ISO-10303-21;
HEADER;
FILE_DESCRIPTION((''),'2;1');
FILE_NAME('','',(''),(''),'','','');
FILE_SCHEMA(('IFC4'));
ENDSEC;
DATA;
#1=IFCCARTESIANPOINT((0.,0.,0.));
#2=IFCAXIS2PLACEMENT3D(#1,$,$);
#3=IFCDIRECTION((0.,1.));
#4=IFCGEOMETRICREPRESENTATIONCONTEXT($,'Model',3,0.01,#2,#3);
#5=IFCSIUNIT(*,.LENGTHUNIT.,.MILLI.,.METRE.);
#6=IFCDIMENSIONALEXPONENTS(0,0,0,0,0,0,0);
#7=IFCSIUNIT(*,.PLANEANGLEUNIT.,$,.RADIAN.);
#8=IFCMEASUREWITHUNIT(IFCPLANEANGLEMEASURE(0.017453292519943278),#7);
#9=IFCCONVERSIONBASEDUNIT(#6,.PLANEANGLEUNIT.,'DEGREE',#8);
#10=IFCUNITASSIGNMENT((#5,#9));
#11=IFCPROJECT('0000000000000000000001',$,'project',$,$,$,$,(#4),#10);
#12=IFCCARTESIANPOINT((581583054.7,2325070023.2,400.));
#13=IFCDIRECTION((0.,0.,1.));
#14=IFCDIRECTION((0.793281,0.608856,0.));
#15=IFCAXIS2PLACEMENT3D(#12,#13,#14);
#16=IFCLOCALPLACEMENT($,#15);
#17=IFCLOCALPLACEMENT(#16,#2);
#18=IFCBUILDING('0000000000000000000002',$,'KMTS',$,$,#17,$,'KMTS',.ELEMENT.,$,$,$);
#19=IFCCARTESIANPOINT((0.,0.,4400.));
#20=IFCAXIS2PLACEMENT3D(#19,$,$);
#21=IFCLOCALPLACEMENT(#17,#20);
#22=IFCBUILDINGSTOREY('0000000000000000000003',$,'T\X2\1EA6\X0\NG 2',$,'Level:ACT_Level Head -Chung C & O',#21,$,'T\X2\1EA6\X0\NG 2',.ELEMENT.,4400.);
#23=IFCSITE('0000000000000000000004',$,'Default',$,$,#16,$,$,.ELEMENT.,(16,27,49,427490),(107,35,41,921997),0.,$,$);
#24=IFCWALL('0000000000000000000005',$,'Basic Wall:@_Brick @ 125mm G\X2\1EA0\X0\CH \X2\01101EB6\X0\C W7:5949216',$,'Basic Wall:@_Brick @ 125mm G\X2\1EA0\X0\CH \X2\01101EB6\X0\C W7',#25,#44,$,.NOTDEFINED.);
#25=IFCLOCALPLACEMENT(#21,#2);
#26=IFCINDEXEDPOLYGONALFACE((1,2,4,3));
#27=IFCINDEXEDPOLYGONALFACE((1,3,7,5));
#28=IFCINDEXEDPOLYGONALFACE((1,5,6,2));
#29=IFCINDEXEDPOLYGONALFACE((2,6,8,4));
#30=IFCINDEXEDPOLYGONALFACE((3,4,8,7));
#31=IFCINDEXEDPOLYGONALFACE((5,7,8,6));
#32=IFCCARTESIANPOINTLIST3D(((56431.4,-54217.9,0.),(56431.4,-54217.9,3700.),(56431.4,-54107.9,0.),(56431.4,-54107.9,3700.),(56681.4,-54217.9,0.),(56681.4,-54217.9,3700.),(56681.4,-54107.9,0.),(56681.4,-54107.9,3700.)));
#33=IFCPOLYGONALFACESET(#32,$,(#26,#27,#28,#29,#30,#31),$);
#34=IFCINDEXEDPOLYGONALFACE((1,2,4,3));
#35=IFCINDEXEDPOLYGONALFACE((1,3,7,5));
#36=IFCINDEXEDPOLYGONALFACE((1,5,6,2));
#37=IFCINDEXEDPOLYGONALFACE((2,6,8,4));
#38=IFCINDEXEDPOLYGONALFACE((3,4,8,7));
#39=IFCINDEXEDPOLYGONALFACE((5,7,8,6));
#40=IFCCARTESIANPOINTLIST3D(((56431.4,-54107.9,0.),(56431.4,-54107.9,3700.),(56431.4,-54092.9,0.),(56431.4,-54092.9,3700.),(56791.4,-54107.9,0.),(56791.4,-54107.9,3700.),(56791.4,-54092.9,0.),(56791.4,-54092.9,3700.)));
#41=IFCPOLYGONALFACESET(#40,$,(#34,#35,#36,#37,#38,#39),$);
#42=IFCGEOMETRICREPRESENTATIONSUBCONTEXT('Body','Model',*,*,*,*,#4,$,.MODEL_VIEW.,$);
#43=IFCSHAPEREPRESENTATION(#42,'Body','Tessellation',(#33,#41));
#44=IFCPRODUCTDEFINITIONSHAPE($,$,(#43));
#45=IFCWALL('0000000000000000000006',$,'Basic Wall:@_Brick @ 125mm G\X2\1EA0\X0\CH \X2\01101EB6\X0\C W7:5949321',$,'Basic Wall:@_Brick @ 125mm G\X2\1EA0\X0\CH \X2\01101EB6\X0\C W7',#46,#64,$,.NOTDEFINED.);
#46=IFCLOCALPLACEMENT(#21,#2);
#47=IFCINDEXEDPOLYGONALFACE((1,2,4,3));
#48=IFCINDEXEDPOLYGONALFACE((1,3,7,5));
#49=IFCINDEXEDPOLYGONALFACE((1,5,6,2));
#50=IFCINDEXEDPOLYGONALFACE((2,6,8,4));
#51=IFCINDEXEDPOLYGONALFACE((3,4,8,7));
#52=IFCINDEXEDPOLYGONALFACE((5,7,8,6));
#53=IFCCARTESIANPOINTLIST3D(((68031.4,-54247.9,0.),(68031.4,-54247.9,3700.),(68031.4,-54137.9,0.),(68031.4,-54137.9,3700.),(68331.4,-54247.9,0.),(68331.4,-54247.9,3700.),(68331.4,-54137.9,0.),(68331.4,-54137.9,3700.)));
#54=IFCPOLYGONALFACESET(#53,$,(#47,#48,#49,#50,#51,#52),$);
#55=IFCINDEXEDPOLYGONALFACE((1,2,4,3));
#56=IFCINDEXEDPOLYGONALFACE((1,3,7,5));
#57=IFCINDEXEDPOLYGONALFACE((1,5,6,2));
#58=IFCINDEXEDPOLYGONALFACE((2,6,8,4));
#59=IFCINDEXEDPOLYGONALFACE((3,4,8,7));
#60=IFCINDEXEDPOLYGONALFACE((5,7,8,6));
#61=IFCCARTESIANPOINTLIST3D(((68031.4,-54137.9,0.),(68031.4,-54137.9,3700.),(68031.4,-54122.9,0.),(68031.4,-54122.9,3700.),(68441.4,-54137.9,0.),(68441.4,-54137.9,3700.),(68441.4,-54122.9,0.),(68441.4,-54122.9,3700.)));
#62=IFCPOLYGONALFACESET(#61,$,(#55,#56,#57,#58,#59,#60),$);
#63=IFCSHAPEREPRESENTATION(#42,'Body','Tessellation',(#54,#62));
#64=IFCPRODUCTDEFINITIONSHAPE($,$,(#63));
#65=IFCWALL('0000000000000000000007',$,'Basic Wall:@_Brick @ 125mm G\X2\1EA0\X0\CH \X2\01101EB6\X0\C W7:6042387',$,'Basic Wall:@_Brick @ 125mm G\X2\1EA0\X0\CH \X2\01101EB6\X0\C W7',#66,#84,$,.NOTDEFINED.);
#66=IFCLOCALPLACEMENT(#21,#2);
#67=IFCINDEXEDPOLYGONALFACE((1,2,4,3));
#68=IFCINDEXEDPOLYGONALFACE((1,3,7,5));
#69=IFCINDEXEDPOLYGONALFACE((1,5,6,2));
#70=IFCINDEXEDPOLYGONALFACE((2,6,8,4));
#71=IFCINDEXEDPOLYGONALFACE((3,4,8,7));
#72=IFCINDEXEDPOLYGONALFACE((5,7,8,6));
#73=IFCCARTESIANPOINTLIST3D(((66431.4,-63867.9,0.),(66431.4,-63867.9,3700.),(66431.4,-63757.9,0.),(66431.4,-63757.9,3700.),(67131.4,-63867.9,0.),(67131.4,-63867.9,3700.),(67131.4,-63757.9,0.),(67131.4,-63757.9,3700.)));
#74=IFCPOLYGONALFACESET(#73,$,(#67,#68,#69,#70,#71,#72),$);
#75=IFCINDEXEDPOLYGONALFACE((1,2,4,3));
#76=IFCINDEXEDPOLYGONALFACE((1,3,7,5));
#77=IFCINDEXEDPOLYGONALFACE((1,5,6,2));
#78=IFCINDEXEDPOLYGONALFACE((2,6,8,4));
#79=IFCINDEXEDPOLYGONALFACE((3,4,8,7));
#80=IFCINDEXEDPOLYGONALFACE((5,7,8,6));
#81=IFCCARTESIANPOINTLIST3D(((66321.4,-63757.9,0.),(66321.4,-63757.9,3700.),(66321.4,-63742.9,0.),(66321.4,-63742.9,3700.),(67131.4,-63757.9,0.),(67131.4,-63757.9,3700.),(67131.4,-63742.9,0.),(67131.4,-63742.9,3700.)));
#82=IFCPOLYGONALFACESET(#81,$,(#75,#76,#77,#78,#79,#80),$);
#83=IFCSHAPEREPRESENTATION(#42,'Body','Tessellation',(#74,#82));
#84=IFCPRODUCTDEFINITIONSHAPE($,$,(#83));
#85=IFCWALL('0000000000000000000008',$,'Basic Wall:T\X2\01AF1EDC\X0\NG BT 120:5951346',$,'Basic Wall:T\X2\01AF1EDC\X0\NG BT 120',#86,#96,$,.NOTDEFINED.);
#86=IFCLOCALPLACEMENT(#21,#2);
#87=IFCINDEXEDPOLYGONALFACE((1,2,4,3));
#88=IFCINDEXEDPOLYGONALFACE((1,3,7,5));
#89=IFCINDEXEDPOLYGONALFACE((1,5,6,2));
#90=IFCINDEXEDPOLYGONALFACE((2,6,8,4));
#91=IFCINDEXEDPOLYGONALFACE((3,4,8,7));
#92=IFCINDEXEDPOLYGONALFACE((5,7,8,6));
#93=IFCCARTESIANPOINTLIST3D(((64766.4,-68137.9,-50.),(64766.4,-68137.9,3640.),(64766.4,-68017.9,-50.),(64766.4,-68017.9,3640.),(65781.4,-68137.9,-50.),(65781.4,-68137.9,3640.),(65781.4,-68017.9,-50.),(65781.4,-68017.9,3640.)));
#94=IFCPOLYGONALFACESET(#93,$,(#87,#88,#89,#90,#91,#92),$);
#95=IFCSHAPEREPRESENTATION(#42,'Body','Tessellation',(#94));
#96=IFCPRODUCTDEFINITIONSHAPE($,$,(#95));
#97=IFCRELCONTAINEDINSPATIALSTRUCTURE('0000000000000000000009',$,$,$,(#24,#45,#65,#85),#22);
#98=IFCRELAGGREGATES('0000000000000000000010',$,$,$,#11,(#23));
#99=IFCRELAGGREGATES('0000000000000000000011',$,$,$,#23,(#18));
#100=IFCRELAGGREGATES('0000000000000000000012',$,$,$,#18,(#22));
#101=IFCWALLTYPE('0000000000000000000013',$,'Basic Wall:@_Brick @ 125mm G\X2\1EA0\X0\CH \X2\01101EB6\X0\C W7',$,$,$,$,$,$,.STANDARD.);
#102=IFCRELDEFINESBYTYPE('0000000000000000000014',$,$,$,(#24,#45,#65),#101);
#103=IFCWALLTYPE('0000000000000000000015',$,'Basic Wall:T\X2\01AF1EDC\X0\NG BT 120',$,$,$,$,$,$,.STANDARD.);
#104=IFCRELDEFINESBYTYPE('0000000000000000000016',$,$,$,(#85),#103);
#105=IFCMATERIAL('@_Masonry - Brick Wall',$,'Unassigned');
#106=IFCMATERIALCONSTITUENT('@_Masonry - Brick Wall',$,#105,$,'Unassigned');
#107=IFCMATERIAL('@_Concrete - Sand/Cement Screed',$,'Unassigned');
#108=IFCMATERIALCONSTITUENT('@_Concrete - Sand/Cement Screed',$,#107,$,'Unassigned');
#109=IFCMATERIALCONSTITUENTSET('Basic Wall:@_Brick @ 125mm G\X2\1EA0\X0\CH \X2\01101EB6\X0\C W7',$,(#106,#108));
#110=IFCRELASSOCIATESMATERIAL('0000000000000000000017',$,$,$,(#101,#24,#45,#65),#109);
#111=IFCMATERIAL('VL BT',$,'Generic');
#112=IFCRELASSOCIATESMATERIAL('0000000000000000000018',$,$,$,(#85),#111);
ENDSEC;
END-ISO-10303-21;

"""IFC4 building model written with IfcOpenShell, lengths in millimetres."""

from ifc_helpers import new_model, entity, si_unit, converted_unit, direction, frame, origin, place, context, subcontext, project, spatial, indexed_curve, outline, extrude, material, constituent, constituent_set, type_object, element, save


model = new_model("IFC4")

# Units and contexts
model_context = context("Model", 3, precision=0.01, world=origin(), true_north=direction((0.0, 1.0)))
body_context = subcontext(model_context, "Body", "Model", "MODEL_VIEW")
ifc_project = project(units=[si_unit("LENGTHUNIT", "METRE", prefix="MILLI"), converted_unit("PLANEANGLEUNIT", "DEGREE", entity("IfcPlaneAngleMeasure", 0.017453292519943278), si_unit("PLANEANGLEUNIT", "RADIAN"), dimensions=[0, 0, 0, 0, 0, 0, 0])], contexts=[model_context])

# Site, building, storey
site_placement = place(None, frame((581583054.7, 2325070023.2, 400.0), z_axis=(0.0, 0.0, 1.0), x_axis=(0.793281, 0.608856, 0.0)))
site = spatial("IfcSite", under=ifc_project, at=site_placement, Name="Default", CompositionType="ELEMENT", RefLatitude=(16, 27, 49, 427490), RefLongitude=(107, 35, 41, 921997), RefElevation=0.0)
building_placement = place(site_placement, origin())
building = spatial("IfcBuilding", under=site, at=building_placement, Name="KMTS", LongName="KMTS", CompositionType="ELEMENT")
storey_placement = place(building_placement, frame((0.0, 0.0, 4400.0)))
storey = spatial("IfcBuildingStorey", under=building, at=storey_placement, Name="TẦNG 2", ObjectType="Level:ACT_Level Head -Chung C & O", LongName="TẦNG 2", CompositionType="ELEMENT", Elevation=4400.0)

# Shared definitions
ifc_material_1 = material(Name="VL BT", Category="Generic")

# Walls
ifc_material_2 = material(Name="@_Masonry - Brick Wall", Category="Unassigned")
ifc_constituent_1 = constituent(ifc_material_2, Name="@_Masonry - Brick Wall", Category="Unassigned")
ifc_material_3 = material(Name="@_Concrete - Sand/Cement Screed", Category="Unassigned")
ifc_constituent_2 = constituent(ifc_material_3, Name="@_Concrete - Sand/Cement Screed", Category="Unassigned")
ifc_constituent_set_1 = constituent_set(constituents=[ifc_constituent_1, ifc_constituent_2], Name="Basic Wall:@_Brick @ 125mm GẠCH ĐẶC W7")
wall_type_1 = type_object("IfcWallType", Name="Basic Wall:@_Brick @ 125mm GẠCH ĐẶC W7", PredefinedType="STANDARD", material=ifc_constituent_set_1)
wall_1_placement = place(storey_placement, frame((56681.4, -54155.4, 0.0), z_axis=(0.0, 0.0, 1.0), x_axis=(-1.0, 0.0, 0.0)))
element("IfcWall", 1, at=wall_1_placement, inside=storey, type_object=wall_type_1, material=ifc_constituent_set_1, Name="Basic Wall:@_Brick @ 125mm GẠCH ĐẶC W7:5949216", ObjectType="Basic Wall:@_Brick @ 125mm GẠCH ĐẶC W7", PredefinedType="NOTDEFINED", context=body_context, shape_type="SweptSolid", body=[
    extrude(outline(indexed_curve([(-55.0, -125.0), (55.0, -125.0), (55.0, 125.0), (-55.0, 125.0), (-55.0, -125.0)], self_intersect=False)), frame((125.0, 7.5, 0.0), z_axis=(0.0, 0.0, 1.0), x_axis=(0.0, -1.0, 0.0)), (0.0, 0.0, 1.0), 3700.0),
    extrude(outline(indexed_curve([(-7.5, -180.0), (7.5, -180.0), (7.5, 180.0), (-7.5, 180.0), (-7.5, -180.0)], self_intersect=False)), frame((70.0, -55.0, 0.0), z_axis=(0.0, 0.0, 1.0), x_axis=(0.0, 1.0, 0.0)), (0.0, 0.0, 1.0), 3700.0),
])
wall_2_placement = place(storey_placement, frame((68331.4, -54185.4, 0.0), z_axis=(0.0, 0.0, 1.0), x_axis=(-1.0, 0.0, 0.0)))
element("IfcWall", 2, at=wall_2_placement, inside=storey, type_object=wall_type_1, material=ifc_constituent_set_1, Name="Basic Wall:@_Brick @ 125mm GẠCH ĐẶC W7:5949321", ObjectType="Basic Wall:@_Brick @ 125mm GẠCH ĐẶC W7", PredefinedType="NOTDEFINED", context=body_context, shape_type="SweptSolid", body=[
    extrude(outline(indexed_curve([(-55.0, -150.0), (55.0, -150.0), (55.0, 150.0), (-55.0, 150.0), (-55.0, -150.0)], self_intersect=False)), frame((150.0, 7.5, 0.0), z_axis=(0.0, 0.0, 1.0), x_axis=(0.0, -1.0, 0.0)), (0.0, 0.0, 1.0), 3700.0),
    extrude(outline(indexed_curve([(-7.5, -205.0), (7.5, -205.0), (7.5, 205.0), (-7.5, 205.0), (-7.5, -205.0)], self_intersect=False)), frame((95.0, -55.0, 0.0), z_axis=(0.0, 0.0, 1.0), x_axis=(0.0, 1.0, 0.0)), (0.0, 0.0, 1.0), 3700.0),
])
wall_3_placement = place(storey_placement, frame((66431.4, -63805.4, 0.0)))
element("IfcWall", 3, at=wall_3_placement, inside=storey, type_object=wall_type_1, material=ifc_constituent_set_1, Name="Basic Wall:@_Brick @ 125mm GẠCH ĐẶC W7:6042387", ObjectType="Basic Wall:@_Brick @ 125mm GẠCH ĐẶC W7", PredefinedType="NOTDEFINED", context=body_context, shape_type="SweptSolid", body=[
    extrude(outline(indexed_curve([(-55.0, -350.0), (55.0, -350.0), (55.0, 350.0), (-55.0, 350.0), (-55.0, -350.0)], self_intersect=False)), frame((350.0, -7.5, 0.0), z_axis=(0.0, 0.0, 1.0), x_axis=(0.0, 1.0, 0.0)), (0.0, 0.0, 1.0), 3700.0),
    extrude(outline(indexed_curve([(-7.5, -405.0), (7.5, -405.0), (7.5, 405.0), (-7.5, 405.0), (-7.5, -405.0)], self_intersect=False)), frame((295.0, 55.0, 0.0), z_axis=(0.0, 0.0, 1.0), x_axis=(0.0, -1.0, 0.0)), (0.0, 0.0, 1.0), 3700.0),
])
wall_type_2 = type_object("IfcWallType", Name="Basic Wall:TƯỜNG BT 120", PredefinedType="STANDARD")
wall_4_placement = place(storey_placement, frame((64766.4, -68077.9, -50.0)))
element("IfcWall", 4, at=wall_4_placement, inside=storey, type_object=wall_type_2, material=ifc_material_1, Name="Basic Wall:TƯỜNG BT 120:5951346", ObjectType="Basic Wall:TƯỜNG BT 120", PredefinedType="NOTDEFINED", context=body_context, shape_type="SweptSolid", body=[
    extrude(outline(indexed_curve([(1015.0, 60.0), (0.0, 60.0), (0.0, -60.0), (1015.0, -60.0), (1015.0, 60.0)], self_intersect=False)), origin(), (0.0, 0.0, 1.0), 3690.0),
])

save(model, "model.ifc")
